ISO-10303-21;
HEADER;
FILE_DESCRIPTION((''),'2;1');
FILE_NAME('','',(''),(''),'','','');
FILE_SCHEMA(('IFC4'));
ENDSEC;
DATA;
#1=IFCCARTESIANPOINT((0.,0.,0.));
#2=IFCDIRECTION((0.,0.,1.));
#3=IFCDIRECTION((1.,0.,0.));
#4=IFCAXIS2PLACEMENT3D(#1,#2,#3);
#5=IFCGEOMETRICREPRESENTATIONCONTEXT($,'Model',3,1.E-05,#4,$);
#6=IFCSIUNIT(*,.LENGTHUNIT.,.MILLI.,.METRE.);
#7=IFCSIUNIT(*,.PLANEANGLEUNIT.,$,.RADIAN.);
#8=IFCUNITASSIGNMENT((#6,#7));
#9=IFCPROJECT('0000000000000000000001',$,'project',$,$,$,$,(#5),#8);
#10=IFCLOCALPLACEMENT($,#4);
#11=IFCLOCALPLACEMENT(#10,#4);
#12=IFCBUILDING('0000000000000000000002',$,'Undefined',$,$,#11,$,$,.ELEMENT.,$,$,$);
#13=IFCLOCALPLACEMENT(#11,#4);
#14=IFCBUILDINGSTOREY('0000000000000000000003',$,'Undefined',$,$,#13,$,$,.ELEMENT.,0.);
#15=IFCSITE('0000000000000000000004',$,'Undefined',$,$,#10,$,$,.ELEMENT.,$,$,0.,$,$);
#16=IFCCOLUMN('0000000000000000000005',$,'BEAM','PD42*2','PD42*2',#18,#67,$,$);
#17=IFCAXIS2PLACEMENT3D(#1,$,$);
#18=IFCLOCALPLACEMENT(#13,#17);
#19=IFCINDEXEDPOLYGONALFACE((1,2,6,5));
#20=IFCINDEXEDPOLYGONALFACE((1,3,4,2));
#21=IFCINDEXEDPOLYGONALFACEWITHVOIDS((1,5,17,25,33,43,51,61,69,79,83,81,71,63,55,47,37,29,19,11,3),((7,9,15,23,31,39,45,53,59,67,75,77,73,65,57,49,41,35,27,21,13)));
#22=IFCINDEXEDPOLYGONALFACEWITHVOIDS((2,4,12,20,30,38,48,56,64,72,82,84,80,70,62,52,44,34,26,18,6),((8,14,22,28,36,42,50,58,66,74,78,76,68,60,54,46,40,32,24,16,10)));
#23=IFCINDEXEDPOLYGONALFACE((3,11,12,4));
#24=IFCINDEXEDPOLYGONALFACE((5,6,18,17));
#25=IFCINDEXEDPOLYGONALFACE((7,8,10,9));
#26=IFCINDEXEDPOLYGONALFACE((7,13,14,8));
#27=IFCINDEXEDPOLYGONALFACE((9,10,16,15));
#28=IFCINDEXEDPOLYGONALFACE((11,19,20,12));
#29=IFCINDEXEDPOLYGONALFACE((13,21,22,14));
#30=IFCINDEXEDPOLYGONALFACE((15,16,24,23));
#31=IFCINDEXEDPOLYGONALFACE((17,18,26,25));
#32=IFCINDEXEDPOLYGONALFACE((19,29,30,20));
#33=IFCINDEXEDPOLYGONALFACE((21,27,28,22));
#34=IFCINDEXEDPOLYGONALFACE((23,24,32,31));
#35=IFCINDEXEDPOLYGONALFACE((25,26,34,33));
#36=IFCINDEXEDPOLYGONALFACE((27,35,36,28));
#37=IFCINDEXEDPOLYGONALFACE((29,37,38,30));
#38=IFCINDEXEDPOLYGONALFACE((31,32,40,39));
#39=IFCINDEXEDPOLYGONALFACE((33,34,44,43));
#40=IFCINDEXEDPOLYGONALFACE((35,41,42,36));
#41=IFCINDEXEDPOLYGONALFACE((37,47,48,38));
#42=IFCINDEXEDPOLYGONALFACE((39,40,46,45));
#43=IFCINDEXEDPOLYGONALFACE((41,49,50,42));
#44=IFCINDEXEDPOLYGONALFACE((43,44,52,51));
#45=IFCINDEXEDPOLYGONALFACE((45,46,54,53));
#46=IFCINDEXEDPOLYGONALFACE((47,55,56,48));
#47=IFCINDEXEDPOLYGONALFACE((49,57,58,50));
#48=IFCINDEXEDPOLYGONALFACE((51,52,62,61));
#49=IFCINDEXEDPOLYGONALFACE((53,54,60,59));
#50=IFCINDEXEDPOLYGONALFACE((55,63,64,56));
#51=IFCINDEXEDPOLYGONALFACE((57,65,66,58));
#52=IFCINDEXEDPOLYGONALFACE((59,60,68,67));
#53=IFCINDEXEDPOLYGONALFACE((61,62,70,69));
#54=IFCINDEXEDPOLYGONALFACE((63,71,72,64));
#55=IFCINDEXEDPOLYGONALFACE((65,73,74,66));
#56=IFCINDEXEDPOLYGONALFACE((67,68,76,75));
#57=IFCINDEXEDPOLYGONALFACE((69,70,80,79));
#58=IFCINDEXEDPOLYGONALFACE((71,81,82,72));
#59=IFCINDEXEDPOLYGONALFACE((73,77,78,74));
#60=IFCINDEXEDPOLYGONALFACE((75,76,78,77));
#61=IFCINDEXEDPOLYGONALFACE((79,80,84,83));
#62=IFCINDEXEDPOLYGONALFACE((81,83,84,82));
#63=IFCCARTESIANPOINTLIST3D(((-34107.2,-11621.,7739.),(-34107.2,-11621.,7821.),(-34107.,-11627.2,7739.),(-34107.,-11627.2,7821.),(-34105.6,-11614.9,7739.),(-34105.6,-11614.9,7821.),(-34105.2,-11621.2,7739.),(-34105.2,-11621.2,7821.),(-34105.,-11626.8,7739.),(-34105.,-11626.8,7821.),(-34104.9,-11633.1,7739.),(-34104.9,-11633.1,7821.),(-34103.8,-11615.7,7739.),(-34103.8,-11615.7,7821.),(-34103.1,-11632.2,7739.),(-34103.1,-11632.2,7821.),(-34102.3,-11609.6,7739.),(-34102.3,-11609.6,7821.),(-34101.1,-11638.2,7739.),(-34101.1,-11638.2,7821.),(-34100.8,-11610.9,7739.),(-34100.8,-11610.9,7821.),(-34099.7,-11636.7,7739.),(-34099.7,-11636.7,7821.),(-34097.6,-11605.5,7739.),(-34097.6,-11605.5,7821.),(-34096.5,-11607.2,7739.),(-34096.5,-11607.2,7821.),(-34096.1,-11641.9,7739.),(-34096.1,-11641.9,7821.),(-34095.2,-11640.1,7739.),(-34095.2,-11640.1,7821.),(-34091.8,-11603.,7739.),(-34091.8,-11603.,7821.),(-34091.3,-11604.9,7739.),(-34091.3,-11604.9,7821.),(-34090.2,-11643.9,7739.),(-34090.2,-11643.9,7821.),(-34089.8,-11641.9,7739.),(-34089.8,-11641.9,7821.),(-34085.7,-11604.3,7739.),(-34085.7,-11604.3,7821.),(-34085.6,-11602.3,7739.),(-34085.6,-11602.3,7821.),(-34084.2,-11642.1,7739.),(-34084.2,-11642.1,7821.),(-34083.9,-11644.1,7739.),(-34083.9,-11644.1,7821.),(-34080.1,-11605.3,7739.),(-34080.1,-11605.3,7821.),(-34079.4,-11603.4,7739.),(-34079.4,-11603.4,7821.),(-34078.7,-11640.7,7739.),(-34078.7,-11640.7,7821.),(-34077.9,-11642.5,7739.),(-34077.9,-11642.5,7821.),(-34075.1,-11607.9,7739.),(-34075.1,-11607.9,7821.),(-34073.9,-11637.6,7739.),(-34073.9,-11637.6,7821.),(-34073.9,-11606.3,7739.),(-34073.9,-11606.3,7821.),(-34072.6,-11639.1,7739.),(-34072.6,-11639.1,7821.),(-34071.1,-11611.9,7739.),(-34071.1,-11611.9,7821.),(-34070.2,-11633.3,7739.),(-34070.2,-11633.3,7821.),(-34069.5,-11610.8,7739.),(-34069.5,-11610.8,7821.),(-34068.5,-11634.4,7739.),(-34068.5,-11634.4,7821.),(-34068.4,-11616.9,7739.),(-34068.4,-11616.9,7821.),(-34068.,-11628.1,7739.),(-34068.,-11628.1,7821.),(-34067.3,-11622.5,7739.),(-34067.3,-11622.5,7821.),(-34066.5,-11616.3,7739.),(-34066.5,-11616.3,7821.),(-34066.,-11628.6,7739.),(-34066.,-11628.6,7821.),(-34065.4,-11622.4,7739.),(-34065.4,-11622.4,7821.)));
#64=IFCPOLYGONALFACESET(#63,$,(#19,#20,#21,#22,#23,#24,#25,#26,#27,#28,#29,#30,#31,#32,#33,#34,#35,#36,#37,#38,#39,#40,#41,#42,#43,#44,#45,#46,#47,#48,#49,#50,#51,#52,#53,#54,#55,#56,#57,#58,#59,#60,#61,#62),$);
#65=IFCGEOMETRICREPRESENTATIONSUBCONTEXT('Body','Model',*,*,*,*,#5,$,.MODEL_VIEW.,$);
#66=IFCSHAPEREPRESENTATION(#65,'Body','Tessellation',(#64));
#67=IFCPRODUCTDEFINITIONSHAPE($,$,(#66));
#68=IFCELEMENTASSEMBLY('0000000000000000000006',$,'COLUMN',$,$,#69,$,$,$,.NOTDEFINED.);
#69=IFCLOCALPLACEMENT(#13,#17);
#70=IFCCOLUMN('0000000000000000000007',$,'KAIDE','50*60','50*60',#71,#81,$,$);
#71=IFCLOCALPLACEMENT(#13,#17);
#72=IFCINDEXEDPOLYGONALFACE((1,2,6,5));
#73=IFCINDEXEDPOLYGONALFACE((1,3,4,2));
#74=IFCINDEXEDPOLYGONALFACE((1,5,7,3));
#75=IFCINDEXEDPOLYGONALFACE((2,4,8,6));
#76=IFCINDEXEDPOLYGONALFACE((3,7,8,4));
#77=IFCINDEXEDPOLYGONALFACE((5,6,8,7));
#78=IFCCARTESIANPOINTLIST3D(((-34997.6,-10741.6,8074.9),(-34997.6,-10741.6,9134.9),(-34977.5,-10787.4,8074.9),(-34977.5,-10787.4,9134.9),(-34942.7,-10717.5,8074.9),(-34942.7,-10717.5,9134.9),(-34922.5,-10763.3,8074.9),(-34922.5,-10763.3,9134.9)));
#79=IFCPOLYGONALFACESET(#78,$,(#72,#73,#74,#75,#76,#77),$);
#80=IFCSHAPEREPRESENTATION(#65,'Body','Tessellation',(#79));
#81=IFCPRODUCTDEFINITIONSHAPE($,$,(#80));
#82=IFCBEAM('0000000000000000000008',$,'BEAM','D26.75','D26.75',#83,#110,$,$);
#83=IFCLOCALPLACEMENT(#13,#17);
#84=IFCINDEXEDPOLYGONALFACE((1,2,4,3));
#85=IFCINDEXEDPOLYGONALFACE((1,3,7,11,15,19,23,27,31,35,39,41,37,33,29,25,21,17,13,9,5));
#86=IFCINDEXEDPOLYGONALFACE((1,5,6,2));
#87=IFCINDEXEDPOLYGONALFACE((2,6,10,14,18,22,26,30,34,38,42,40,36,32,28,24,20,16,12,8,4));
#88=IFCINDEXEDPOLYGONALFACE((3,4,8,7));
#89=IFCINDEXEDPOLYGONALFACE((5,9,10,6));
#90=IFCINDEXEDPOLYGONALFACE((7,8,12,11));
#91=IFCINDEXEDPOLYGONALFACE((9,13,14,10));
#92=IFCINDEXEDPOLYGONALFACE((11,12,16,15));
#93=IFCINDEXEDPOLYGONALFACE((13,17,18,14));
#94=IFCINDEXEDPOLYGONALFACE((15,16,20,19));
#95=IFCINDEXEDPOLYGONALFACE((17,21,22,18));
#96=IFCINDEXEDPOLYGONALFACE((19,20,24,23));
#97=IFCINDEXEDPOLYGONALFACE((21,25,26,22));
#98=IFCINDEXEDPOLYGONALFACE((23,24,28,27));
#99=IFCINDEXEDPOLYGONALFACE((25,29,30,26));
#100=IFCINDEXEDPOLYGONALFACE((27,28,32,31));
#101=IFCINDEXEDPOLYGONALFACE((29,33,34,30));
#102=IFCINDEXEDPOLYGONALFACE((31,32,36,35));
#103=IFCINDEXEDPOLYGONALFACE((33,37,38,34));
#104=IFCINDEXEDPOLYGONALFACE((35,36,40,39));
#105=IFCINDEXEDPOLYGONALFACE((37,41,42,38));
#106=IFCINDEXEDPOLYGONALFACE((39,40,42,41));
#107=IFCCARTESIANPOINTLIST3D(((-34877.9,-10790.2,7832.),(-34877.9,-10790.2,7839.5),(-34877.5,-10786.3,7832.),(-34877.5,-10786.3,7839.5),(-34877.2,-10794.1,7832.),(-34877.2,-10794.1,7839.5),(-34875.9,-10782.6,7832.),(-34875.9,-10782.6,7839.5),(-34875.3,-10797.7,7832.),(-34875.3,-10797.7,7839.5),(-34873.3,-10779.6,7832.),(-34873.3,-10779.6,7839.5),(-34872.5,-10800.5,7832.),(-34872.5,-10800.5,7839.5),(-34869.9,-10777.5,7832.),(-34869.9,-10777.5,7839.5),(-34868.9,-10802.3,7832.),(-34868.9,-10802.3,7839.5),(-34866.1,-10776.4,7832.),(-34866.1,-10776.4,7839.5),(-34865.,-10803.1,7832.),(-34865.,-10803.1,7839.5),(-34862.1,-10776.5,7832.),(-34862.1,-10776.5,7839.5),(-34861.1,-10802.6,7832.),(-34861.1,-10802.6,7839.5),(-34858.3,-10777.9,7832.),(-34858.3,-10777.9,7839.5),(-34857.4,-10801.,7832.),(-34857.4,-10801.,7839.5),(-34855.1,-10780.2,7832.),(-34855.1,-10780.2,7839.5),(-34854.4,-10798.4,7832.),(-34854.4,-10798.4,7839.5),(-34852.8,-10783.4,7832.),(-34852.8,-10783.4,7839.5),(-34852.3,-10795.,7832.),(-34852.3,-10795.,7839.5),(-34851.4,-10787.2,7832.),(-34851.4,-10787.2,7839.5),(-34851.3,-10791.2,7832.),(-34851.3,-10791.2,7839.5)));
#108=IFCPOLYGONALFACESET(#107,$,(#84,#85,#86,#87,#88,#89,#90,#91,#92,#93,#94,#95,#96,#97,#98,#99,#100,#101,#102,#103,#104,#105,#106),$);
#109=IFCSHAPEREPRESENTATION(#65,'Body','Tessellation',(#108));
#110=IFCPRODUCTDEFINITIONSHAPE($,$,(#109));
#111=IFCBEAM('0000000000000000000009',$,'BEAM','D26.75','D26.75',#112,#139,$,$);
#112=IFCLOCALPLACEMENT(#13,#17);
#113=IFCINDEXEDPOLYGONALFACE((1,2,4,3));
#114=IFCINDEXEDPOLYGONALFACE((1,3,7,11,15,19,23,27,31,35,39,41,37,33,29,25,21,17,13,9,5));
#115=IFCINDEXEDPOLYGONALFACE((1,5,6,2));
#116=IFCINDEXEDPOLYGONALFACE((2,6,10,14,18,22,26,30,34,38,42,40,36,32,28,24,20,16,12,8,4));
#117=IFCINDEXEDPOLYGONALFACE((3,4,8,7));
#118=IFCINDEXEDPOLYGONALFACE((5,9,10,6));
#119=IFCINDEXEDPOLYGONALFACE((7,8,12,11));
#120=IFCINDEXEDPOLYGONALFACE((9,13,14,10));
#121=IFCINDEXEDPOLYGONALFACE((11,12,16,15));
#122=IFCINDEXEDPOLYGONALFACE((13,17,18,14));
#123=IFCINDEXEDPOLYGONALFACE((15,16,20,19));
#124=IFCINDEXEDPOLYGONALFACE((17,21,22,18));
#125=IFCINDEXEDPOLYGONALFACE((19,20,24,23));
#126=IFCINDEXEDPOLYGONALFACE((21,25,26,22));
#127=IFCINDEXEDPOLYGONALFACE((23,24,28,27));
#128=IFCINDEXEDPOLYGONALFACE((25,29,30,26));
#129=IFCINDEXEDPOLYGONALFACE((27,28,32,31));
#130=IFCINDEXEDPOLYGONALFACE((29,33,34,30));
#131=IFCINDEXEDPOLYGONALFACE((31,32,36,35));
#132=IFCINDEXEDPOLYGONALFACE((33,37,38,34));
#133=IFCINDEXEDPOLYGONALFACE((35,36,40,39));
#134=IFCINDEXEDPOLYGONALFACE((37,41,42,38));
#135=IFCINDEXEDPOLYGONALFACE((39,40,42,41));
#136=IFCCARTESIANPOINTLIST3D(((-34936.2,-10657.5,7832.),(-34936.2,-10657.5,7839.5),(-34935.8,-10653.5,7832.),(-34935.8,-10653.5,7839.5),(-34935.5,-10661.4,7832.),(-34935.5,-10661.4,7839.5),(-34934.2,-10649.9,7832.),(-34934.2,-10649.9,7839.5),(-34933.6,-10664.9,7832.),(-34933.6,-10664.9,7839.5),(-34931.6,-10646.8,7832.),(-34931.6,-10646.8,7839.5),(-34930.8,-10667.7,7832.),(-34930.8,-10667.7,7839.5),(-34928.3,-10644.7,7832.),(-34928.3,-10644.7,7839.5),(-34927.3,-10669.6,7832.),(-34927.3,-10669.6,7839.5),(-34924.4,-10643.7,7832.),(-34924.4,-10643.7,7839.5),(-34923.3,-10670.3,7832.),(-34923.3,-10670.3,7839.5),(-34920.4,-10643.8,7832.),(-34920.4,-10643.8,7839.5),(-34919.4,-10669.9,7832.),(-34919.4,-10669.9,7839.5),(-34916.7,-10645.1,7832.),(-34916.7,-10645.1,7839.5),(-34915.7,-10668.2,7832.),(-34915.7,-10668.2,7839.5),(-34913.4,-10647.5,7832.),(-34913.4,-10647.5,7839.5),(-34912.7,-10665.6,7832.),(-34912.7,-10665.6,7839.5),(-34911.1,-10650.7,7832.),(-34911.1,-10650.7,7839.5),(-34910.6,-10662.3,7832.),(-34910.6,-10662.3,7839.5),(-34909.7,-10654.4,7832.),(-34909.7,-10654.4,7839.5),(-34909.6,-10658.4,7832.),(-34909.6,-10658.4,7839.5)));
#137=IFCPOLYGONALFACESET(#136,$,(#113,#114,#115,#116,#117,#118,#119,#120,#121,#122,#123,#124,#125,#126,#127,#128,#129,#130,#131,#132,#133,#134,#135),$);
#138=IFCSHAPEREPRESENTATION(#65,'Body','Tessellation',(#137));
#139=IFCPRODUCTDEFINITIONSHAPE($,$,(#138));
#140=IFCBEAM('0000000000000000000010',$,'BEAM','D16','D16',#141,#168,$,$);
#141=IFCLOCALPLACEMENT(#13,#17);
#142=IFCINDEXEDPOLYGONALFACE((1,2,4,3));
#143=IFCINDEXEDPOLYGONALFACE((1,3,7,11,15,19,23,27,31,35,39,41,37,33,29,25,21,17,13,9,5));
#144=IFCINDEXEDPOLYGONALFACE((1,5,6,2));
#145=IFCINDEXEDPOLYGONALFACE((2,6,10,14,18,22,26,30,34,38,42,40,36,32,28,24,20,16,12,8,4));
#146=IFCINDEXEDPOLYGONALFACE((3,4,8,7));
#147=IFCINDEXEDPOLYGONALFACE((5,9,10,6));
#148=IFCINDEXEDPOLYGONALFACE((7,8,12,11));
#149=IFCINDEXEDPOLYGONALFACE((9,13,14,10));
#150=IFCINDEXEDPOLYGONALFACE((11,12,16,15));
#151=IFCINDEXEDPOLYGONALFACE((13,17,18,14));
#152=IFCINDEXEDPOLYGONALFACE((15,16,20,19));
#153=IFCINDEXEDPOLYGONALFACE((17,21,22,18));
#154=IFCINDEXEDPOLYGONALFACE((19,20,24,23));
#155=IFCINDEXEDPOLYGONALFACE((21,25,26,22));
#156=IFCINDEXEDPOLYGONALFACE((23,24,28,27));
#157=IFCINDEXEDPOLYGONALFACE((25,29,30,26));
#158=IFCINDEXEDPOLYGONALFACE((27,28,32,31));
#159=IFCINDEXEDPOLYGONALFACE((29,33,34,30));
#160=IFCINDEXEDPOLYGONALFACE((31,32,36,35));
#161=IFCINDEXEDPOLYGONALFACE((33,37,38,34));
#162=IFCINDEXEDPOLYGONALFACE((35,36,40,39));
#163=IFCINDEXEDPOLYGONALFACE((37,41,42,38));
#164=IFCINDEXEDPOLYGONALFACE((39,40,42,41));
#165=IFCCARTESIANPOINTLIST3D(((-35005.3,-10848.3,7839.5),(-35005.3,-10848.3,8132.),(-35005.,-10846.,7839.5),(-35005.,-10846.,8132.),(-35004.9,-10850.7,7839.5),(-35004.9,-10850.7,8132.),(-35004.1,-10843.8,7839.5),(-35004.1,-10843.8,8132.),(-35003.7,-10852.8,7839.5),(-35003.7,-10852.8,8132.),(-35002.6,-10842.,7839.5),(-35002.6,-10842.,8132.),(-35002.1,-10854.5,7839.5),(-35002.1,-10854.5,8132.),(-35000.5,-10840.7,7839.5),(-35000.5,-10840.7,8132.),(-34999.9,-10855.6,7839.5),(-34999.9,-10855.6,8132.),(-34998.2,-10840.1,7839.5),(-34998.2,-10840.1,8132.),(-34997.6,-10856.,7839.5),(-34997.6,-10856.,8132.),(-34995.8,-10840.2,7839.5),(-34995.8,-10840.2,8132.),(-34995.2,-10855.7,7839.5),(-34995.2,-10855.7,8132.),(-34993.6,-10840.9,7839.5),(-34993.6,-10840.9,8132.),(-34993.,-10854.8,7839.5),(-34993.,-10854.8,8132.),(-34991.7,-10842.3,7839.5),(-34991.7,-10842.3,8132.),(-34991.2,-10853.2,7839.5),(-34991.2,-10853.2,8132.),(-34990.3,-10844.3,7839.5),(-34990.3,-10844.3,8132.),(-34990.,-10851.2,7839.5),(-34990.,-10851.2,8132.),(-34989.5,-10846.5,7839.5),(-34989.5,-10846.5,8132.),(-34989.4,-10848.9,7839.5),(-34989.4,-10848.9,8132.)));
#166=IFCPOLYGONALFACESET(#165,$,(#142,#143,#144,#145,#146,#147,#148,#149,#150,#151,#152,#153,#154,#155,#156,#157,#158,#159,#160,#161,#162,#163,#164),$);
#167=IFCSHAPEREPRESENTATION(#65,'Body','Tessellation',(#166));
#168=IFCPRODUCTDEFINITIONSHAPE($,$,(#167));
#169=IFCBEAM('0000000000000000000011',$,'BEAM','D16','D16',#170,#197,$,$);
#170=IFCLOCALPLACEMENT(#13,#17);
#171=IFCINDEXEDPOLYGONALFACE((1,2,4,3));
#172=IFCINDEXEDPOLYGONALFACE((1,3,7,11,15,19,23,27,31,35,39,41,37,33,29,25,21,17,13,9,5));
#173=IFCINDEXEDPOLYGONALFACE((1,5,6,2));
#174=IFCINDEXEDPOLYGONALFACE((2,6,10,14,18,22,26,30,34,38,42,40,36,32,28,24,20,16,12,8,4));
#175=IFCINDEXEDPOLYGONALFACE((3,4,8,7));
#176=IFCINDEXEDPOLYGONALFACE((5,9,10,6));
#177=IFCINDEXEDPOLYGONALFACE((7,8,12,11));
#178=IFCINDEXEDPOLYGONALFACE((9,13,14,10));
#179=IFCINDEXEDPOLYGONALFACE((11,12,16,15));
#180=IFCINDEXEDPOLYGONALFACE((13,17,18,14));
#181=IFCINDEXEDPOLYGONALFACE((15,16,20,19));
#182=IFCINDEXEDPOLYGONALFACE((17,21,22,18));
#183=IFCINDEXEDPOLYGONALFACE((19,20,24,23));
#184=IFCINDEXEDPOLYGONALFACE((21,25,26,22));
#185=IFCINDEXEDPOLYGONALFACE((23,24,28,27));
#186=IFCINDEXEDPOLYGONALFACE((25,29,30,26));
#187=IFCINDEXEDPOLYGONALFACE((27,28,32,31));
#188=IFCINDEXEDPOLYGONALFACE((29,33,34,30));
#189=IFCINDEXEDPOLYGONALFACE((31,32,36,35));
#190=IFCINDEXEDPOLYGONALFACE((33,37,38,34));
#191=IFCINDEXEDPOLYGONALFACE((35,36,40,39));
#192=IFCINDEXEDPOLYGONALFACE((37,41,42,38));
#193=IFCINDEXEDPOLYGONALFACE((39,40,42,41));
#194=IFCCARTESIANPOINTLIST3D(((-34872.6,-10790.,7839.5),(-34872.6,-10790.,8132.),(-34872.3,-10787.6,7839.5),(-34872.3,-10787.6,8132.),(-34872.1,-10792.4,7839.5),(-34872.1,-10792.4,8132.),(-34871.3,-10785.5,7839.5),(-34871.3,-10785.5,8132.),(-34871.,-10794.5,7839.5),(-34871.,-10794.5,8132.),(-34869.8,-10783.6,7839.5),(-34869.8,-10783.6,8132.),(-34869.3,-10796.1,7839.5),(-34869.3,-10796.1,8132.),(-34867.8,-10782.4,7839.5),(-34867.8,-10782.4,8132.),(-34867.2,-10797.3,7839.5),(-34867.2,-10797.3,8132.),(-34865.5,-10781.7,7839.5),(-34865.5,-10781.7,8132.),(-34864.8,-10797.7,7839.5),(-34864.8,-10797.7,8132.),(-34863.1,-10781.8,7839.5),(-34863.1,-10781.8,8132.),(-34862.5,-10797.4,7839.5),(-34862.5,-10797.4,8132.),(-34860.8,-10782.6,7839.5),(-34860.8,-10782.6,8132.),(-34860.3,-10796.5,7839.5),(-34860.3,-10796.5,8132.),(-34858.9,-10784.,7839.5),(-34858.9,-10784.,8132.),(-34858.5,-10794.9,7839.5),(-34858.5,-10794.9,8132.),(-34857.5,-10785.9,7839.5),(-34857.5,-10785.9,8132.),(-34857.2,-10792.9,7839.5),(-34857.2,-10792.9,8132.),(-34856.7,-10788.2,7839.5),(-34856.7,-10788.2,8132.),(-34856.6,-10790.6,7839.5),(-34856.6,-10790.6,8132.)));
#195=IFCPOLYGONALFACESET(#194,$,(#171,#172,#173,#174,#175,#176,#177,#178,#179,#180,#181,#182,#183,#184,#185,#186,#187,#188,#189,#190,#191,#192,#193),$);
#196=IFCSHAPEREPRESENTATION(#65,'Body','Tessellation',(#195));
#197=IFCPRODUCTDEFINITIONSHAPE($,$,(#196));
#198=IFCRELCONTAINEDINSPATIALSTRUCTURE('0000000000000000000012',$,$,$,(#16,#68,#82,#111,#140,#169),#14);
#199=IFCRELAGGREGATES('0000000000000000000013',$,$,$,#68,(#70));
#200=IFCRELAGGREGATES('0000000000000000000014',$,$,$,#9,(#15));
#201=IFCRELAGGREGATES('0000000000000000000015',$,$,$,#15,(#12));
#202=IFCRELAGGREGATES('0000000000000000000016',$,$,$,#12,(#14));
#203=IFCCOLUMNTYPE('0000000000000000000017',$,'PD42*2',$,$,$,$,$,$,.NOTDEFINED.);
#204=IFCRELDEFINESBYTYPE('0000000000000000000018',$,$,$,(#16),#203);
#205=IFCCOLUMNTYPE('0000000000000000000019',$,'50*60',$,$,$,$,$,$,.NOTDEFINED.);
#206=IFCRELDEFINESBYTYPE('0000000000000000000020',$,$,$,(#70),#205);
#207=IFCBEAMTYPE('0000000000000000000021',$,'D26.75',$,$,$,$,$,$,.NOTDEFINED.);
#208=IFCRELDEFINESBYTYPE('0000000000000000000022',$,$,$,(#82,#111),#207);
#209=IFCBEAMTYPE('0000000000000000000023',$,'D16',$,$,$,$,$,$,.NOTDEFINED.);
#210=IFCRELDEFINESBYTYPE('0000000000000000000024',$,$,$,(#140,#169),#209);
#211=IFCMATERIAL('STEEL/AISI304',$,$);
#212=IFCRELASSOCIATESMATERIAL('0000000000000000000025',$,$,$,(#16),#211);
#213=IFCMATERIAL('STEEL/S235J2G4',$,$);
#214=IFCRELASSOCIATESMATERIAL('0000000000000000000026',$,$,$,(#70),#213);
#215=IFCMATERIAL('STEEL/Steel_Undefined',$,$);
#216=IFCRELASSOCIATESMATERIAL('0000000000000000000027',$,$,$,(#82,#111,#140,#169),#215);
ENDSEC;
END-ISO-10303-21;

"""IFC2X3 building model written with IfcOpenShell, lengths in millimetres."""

from ifc_helpers import new_model, si_unit, frame, origin_with_axes, origin_2d_with_axis, place, context, subcontext, project, spatial, rectangle, circle, hollow_circle, extrude, material, type_object, element, aggregate, save


model = new_model("IFC2X3")

# Units and contexts
model_context = context("Model", 3, precision=1e-05, world=origin_with_axes())
body_context = subcontext(model_context, "Body", "Model", "MODEL_VIEW")
ifc_project = project(units=[si_unit("LENGTHUNIT", "METRE", prefix="MILLI"), si_unit("PLANEANGLEUNIT", "RADIAN")], contexts=[model_context])

# Site, building, storey
site_placement = place(None, origin_with_axes())
site = spatial("IfcSite", under=ifc_project, at=site_placement, Name="Undefined", CompositionType="ELEMENT", RefElevation=0.0)
building_placement = place(site_placement, origin_with_axes())
building = spatial("IfcBuilding", under=site, at=building_placement, Name="Undefined", CompositionType="ELEMENT")
storey_placement = place(building_placement, origin_with_axes())
storey = spatial("IfcBuildingStorey", under=building, at=storey_placement, Name="Undefined", CompositionType="ELEMENT", Elevation=0.0)

# Column
ifc_material_1 = material(Name="STEEL/AISI304")
column_type_1 = type_object("IfcColumnType", Name="PD42*2", PredefinedType="NOTDEFINED")
column_1_placement = place(storey_placement, frame((-34086.3, -11623.3, 7739.0), z_axis=(0.0, 0.0, 1.0), x_axis=(1.0, 0.0, 0.0)))
element("IfcColumn", 1, at=column_1_placement, inside=storey, type_object=column_type_1, material=ifc_material_1, Name="BEAM", Description="PD42*2", ObjectType="PD42*2", context=body_context, shape_type="SweptSolid", body=[
    extrude(hollow_circle(Radius=21.0, WallThickness=2.0, at=origin_2d_with_axis()), frame((0.0, 0.0, 82.0), z_axis=(0.0, 0.0, -1.0), x_axis=(0.402197, -0.915553, 0.0)), (0.0, 0.0, 1.0), 82.0),
])

# Element assembly, column
assembly_placement = place(storey_placement, frame((-34960.1, -10752.5, 8074.9), z_axis=(-0.402198, 0.915553, 0.0), x_axis=(0.0, 0.0, 1.0)))
assembly = element("IfcElementAssembly", 2, at=assembly_placement, inside=storey, Name="COLUMN", PredefinedType="NOTDEFINED")
ifc_material_2 = material(Name="STEEL/S235J2G4")
column_type_2 = type_object("IfcColumnType", Name="50*60", PredefinedType="NOTDEFINED")
column_2_placement = place(storey_placement, frame((-34960.1, -10752.5, 8074.9), z_axis=(0.0, 0.0, 1.0), x_axis=(1.0, 0.0, 0.0)))
column_2 = element("IfcColumn", 3, at=column_2_placement, type_object=column_type_2, material=ifc_material_2, Name="KAIDE", Description="50*60", ObjectType="50*60", context=body_context, shape_type="SweptSolid", body=[
    extrude(rectangle(XDim=60.0, YDim=50.0, at=origin_2d_with_axis()), frame((0.0, 0.0, 1060.0), z_axis=(0.0, 0.0, -1.0), x_axis=(-0.915553, -0.402198, 0.0)), (0.0, 0.0, 1.0), 1060.0),
])
aggregate(assembly, [column_2])

# Shared definitions
ifc_material_3 = material(Name="STEEL/Steel_Undefined")
beam_type_1 = type_object("IfcBeamType", Name="D26.75", PredefinedType="NOTDEFINED")

# Beam
beam_1_placement = place(storey_placement, frame((-34864.6, -10789.7, 7839.5), z_axis=(-0.915553, -0.402198, 0.0), x_axis=(0.0, 0.0, -1.0)))
element("IfcBeam", 4, at=beam_1_placement, inside=storey, type_object=beam_type_1, material=ifc_material_3, Name="BEAM", Description="D26.75", ObjectType="D26.75", context=body_context, shape_type="SweptSolid", body=[
    extrude(circle(Radius=13.4, at=origin_2d_with_axis()), frame((7.4, 0.0, 0.0), z_axis=(-1.0, 0.0, 0.0), x_axis=(0.0, -1.0, 0.0)), (0.0, 0.0, 1.0), 7.4),
])

# Beam
beam_2_placement = place(storey_placement, frame((-34922.9, -10656.9, 7839.5), z_axis=(-0.915553, -0.402198, 0.0), x_axis=(0.0, 0.0, -1.0)))
element("IfcBeam", 5, at=beam_2_placement, inside=storey, type_object=beam_type_1, material=ifc_material_3, Name="BEAM", Description="D26.75", ObjectType="D26.75", context=body_context, shape_type="SweptSolid", body=[
    extrude(circle(Radius=13.4, at=origin_2d_with_axis()), frame((7.4, 0.0, 0.0), z_axis=(-1.0, 0.0, 0.0), x_axis=(0.0, -1.0, 0.0)), (0.0, 0.0, 1.0), 7.4),
])

# Beams
beam_type_2 = type_object("IfcBeamType", Name="D16", PredefinedType="NOTDEFINED")
for number, where, z_axis, x_axis, name in (
    (6, (-34997.3, -10848.0, 8132.0), (-0.915553, -0.402198, 0.0), (0.0, 0.0, -1.0), "BEAM"),
    (7, (-34864.6, -10789.7, 8132.0), (-0.915553, -0.402198, 0.0), (0.0, 0.0, -1.0), "BEAM"),
):
    element("IfcBeam", number, at=place(storey_placement, frame(where, z_axis=z_axis, x_axis=x_axis)), inside=storey, type_object=beam_type_2, material=ifc_material_3, Name=name, Description="D16", ObjectType="D16", context=body_context, shape_type="SweptSolid", body=[
        extrude(circle(Radius=8.0, at=origin_2d_with_axis()), frame((292.6, 0.0, 0.0), z_axis=(-1.0, 0.0, 0.0), x_axis=(0.0, -1.0, 0.0)), (0.0, 0.0, 1.0), 292.6),
    ])

save(model, "model.ifc")
